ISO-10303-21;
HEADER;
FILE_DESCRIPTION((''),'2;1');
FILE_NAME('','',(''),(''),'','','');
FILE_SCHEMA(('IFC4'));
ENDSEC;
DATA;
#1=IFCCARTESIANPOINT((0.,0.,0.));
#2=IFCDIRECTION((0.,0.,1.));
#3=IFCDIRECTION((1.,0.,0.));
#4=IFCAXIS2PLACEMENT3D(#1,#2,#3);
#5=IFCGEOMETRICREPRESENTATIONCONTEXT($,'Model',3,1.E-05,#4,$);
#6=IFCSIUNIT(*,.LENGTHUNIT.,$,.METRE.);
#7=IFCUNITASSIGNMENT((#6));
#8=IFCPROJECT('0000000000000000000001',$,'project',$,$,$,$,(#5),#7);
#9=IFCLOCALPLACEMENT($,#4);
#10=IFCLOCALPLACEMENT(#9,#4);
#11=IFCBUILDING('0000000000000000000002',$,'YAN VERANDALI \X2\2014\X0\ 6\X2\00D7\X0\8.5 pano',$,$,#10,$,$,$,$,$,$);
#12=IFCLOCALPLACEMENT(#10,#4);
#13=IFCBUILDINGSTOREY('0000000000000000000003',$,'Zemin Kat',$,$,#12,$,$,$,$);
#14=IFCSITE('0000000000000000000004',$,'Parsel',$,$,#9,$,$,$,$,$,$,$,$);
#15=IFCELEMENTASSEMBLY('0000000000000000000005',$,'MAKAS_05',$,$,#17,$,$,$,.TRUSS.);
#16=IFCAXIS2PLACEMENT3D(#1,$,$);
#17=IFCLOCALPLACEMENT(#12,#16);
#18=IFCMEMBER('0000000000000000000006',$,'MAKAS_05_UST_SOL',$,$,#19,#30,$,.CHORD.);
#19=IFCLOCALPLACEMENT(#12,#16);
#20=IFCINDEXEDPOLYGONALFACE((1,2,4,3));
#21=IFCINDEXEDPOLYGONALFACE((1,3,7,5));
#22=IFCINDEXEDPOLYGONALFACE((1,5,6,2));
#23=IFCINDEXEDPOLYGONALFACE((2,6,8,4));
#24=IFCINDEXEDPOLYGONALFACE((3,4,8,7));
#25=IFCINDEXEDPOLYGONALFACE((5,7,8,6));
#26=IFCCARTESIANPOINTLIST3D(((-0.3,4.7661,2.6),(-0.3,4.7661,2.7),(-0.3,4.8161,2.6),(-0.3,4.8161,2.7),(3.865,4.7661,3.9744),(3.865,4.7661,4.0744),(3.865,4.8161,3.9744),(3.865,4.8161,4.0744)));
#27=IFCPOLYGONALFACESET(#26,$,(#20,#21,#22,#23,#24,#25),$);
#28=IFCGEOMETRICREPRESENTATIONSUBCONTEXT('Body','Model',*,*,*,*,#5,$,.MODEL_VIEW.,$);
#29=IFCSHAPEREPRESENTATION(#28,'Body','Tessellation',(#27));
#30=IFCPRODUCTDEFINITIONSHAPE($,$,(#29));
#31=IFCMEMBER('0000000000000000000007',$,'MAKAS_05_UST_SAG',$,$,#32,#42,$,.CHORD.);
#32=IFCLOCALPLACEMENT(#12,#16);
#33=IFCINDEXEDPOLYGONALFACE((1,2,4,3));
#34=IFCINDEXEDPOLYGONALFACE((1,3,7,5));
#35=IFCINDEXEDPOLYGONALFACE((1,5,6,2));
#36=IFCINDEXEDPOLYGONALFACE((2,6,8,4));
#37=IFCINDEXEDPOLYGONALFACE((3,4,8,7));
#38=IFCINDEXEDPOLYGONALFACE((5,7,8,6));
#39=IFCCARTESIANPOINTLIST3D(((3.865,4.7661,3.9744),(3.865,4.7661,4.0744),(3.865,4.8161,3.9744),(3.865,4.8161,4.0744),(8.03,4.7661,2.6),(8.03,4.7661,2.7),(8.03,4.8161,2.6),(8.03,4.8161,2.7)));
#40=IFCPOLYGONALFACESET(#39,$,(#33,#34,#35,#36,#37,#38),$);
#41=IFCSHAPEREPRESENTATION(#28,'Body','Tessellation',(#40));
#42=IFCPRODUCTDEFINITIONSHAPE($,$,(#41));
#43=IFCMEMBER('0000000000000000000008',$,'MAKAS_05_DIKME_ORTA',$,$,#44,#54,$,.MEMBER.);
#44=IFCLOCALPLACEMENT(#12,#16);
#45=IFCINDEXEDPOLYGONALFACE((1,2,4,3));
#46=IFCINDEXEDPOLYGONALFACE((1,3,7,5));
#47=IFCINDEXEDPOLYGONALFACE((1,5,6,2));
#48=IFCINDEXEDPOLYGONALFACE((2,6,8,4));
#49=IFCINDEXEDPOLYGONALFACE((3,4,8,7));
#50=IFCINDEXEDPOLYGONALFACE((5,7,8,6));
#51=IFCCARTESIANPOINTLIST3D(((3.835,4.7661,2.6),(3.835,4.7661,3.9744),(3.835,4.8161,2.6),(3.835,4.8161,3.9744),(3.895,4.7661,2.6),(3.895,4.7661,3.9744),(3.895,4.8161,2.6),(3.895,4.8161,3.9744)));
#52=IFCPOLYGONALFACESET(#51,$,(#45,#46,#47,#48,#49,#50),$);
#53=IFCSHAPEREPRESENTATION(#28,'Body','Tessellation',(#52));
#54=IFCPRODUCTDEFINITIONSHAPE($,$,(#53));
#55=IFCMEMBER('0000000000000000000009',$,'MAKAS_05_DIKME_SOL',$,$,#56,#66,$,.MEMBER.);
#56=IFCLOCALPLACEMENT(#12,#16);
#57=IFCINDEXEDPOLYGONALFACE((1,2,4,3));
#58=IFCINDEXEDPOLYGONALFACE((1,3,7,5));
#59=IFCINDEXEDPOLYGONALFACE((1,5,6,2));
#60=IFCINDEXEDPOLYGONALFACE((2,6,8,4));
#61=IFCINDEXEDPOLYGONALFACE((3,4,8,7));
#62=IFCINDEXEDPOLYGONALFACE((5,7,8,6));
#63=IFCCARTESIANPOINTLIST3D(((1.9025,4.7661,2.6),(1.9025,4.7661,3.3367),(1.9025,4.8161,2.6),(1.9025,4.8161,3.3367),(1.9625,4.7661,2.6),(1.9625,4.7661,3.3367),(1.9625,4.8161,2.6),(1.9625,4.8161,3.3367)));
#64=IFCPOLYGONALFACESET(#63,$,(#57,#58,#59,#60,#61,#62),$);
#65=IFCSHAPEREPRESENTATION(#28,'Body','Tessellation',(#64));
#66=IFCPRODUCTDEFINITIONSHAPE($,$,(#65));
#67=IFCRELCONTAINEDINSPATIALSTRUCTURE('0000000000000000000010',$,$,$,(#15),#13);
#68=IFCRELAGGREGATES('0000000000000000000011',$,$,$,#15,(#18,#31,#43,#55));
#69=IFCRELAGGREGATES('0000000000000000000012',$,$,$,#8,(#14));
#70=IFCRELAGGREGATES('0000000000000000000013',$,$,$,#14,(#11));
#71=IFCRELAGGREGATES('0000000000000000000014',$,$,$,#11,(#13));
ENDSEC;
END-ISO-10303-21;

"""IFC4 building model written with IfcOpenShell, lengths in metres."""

from ifc_helpers import new_model, si_unit, frame, origin_with_axes, place, context, subcontext, project, spatial, line, indexed_curve, outline, extrude, element, aggregate, save


model = new_model("IFC4")

# Units and contexts
model_context = context("Model", 3, precision=1e-05, world=origin_with_axes())
body_context = subcontext(model_context, "Body", "Model", "MODEL_VIEW")
ifc_project = project(units=[si_unit("LENGTHUNIT", "METRE")], contexts=[model_context])

# Site, building, storey
site_placement = place(None, origin_with_axes())
site = spatial("IfcSite", under=ifc_project, at=site_placement, Name="Parsel")
building_placement = place(site_placement, origin_with_axes())
building = spatial("IfcBuilding", under=site, at=building_placement, Name="YAN VERANDALI — 6×8.5 pano")
storey_placement = place(building_placement, origin_with_axes())
storey = spatial("IfcBuildingStorey", under=building, at=storey_placement, Name="Zemin Kat")

# Element assembly, members
assembly_1_placement = place(storey_placement, origin_with_axes())
assembly_1 = element("IfcElementAssembly", 1, at=assembly_1_placement, inside=storey, Name="MAKAS_05", PredefinedType="TRUSS")
member_1_placement = place(assembly_1_placement, origin_with_axes())
member_1 = element("IfcMember", 2, at=member_1_placement, Name="MAKAS_05_UST_SOL", PredefinedType="CHORD", context=body_context, shape_type="SweptSolid", body=[
    extrude(outline(indexed_curve([(-0.3, 2.6), (3.865, 3.9745), (3.865, 4.0744), (-0.3, 2.7)], segments=[line(1, 2, 3, 4, 1)])), frame((0.0, 4.8161, 0.0), z_axis=(0.0, -1.0, 0.0), x_axis=(1.0, 0.0, 0.0)), (0.0, 0.0, 1.0), 0.05),
])
member_2_placement = place(assembly_1_placement, origin_with_axes())
member_2 = element("IfcMember", 3, at=member_2_placement, Name="MAKAS_05_UST_SAG", PredefinedType="CHORD", context=body_context, shape_type="SweptSolid", body=[
    extrude(outline(indexed_curve([(3.865, 3.9745), (8.03, 2.6), (8.03, 2.7), (3.865, 4.0744)], segments=[line(1, 2, 3, 4, 1)])), frame((0.0, 4.8161, 0.0), z_axis=(0.0, -1.0, 0.0), x_axis=(1.0, 0.0, 0.0)), (0.0, 0.0, 1.0), 0.05),
])
member_3_placement = place(assembly_1_placement, origin_with_axes())
member_3 = element("IfcMember", 4, at=member_3_placement, Name="MAKAS_05_DIKME_ORTA", PredefinedType="MEMBER", context=body_context, shape_type="SweptSolid", body=[
    extrude(outline(indexed_curve([(3.835, 2.6), (3.895, 2.6), (3.895, 3.9745), (3.835, 3.9745)], segments=[line(1, 2, 3, 4, 1)])), frame((0.0, 4.8161, 0.0), z_axis=(0.0, -1.0, 0.0), x_axis=(1.0, 0.0, 0.0)), (0.0, 0.0, 1.0), 0.05),
])
member_4_placement = place(assembly_1_placement, origin_with_axes())
member_4 = element("IfcMember", 5, at=member_4_placement, Name="MAKAS_05_DIKME_SOL", PredefinedType="MEMBER", context=body_context, shape_type="SweptSolid", body=[
    extrude(outline(indexed_curve([(1.9025, 2.6), (1.9625, 2.6), (1.9625, 3.3367), (1.9025, 3.3367)], segments=[line(1, 2, 3, 4, 1)])), frame((0.0, 4.8161, 0.0), z_axis=(0.0, -1.0, 0.0), x_axis=(1.0, 0.0, 0.0)), (0.0, 0.0, 1.0), 0.05),
])
aggregate(assembly_1, [member_1, member_2, member_3, member_4])

save(model, "model.ifc")
